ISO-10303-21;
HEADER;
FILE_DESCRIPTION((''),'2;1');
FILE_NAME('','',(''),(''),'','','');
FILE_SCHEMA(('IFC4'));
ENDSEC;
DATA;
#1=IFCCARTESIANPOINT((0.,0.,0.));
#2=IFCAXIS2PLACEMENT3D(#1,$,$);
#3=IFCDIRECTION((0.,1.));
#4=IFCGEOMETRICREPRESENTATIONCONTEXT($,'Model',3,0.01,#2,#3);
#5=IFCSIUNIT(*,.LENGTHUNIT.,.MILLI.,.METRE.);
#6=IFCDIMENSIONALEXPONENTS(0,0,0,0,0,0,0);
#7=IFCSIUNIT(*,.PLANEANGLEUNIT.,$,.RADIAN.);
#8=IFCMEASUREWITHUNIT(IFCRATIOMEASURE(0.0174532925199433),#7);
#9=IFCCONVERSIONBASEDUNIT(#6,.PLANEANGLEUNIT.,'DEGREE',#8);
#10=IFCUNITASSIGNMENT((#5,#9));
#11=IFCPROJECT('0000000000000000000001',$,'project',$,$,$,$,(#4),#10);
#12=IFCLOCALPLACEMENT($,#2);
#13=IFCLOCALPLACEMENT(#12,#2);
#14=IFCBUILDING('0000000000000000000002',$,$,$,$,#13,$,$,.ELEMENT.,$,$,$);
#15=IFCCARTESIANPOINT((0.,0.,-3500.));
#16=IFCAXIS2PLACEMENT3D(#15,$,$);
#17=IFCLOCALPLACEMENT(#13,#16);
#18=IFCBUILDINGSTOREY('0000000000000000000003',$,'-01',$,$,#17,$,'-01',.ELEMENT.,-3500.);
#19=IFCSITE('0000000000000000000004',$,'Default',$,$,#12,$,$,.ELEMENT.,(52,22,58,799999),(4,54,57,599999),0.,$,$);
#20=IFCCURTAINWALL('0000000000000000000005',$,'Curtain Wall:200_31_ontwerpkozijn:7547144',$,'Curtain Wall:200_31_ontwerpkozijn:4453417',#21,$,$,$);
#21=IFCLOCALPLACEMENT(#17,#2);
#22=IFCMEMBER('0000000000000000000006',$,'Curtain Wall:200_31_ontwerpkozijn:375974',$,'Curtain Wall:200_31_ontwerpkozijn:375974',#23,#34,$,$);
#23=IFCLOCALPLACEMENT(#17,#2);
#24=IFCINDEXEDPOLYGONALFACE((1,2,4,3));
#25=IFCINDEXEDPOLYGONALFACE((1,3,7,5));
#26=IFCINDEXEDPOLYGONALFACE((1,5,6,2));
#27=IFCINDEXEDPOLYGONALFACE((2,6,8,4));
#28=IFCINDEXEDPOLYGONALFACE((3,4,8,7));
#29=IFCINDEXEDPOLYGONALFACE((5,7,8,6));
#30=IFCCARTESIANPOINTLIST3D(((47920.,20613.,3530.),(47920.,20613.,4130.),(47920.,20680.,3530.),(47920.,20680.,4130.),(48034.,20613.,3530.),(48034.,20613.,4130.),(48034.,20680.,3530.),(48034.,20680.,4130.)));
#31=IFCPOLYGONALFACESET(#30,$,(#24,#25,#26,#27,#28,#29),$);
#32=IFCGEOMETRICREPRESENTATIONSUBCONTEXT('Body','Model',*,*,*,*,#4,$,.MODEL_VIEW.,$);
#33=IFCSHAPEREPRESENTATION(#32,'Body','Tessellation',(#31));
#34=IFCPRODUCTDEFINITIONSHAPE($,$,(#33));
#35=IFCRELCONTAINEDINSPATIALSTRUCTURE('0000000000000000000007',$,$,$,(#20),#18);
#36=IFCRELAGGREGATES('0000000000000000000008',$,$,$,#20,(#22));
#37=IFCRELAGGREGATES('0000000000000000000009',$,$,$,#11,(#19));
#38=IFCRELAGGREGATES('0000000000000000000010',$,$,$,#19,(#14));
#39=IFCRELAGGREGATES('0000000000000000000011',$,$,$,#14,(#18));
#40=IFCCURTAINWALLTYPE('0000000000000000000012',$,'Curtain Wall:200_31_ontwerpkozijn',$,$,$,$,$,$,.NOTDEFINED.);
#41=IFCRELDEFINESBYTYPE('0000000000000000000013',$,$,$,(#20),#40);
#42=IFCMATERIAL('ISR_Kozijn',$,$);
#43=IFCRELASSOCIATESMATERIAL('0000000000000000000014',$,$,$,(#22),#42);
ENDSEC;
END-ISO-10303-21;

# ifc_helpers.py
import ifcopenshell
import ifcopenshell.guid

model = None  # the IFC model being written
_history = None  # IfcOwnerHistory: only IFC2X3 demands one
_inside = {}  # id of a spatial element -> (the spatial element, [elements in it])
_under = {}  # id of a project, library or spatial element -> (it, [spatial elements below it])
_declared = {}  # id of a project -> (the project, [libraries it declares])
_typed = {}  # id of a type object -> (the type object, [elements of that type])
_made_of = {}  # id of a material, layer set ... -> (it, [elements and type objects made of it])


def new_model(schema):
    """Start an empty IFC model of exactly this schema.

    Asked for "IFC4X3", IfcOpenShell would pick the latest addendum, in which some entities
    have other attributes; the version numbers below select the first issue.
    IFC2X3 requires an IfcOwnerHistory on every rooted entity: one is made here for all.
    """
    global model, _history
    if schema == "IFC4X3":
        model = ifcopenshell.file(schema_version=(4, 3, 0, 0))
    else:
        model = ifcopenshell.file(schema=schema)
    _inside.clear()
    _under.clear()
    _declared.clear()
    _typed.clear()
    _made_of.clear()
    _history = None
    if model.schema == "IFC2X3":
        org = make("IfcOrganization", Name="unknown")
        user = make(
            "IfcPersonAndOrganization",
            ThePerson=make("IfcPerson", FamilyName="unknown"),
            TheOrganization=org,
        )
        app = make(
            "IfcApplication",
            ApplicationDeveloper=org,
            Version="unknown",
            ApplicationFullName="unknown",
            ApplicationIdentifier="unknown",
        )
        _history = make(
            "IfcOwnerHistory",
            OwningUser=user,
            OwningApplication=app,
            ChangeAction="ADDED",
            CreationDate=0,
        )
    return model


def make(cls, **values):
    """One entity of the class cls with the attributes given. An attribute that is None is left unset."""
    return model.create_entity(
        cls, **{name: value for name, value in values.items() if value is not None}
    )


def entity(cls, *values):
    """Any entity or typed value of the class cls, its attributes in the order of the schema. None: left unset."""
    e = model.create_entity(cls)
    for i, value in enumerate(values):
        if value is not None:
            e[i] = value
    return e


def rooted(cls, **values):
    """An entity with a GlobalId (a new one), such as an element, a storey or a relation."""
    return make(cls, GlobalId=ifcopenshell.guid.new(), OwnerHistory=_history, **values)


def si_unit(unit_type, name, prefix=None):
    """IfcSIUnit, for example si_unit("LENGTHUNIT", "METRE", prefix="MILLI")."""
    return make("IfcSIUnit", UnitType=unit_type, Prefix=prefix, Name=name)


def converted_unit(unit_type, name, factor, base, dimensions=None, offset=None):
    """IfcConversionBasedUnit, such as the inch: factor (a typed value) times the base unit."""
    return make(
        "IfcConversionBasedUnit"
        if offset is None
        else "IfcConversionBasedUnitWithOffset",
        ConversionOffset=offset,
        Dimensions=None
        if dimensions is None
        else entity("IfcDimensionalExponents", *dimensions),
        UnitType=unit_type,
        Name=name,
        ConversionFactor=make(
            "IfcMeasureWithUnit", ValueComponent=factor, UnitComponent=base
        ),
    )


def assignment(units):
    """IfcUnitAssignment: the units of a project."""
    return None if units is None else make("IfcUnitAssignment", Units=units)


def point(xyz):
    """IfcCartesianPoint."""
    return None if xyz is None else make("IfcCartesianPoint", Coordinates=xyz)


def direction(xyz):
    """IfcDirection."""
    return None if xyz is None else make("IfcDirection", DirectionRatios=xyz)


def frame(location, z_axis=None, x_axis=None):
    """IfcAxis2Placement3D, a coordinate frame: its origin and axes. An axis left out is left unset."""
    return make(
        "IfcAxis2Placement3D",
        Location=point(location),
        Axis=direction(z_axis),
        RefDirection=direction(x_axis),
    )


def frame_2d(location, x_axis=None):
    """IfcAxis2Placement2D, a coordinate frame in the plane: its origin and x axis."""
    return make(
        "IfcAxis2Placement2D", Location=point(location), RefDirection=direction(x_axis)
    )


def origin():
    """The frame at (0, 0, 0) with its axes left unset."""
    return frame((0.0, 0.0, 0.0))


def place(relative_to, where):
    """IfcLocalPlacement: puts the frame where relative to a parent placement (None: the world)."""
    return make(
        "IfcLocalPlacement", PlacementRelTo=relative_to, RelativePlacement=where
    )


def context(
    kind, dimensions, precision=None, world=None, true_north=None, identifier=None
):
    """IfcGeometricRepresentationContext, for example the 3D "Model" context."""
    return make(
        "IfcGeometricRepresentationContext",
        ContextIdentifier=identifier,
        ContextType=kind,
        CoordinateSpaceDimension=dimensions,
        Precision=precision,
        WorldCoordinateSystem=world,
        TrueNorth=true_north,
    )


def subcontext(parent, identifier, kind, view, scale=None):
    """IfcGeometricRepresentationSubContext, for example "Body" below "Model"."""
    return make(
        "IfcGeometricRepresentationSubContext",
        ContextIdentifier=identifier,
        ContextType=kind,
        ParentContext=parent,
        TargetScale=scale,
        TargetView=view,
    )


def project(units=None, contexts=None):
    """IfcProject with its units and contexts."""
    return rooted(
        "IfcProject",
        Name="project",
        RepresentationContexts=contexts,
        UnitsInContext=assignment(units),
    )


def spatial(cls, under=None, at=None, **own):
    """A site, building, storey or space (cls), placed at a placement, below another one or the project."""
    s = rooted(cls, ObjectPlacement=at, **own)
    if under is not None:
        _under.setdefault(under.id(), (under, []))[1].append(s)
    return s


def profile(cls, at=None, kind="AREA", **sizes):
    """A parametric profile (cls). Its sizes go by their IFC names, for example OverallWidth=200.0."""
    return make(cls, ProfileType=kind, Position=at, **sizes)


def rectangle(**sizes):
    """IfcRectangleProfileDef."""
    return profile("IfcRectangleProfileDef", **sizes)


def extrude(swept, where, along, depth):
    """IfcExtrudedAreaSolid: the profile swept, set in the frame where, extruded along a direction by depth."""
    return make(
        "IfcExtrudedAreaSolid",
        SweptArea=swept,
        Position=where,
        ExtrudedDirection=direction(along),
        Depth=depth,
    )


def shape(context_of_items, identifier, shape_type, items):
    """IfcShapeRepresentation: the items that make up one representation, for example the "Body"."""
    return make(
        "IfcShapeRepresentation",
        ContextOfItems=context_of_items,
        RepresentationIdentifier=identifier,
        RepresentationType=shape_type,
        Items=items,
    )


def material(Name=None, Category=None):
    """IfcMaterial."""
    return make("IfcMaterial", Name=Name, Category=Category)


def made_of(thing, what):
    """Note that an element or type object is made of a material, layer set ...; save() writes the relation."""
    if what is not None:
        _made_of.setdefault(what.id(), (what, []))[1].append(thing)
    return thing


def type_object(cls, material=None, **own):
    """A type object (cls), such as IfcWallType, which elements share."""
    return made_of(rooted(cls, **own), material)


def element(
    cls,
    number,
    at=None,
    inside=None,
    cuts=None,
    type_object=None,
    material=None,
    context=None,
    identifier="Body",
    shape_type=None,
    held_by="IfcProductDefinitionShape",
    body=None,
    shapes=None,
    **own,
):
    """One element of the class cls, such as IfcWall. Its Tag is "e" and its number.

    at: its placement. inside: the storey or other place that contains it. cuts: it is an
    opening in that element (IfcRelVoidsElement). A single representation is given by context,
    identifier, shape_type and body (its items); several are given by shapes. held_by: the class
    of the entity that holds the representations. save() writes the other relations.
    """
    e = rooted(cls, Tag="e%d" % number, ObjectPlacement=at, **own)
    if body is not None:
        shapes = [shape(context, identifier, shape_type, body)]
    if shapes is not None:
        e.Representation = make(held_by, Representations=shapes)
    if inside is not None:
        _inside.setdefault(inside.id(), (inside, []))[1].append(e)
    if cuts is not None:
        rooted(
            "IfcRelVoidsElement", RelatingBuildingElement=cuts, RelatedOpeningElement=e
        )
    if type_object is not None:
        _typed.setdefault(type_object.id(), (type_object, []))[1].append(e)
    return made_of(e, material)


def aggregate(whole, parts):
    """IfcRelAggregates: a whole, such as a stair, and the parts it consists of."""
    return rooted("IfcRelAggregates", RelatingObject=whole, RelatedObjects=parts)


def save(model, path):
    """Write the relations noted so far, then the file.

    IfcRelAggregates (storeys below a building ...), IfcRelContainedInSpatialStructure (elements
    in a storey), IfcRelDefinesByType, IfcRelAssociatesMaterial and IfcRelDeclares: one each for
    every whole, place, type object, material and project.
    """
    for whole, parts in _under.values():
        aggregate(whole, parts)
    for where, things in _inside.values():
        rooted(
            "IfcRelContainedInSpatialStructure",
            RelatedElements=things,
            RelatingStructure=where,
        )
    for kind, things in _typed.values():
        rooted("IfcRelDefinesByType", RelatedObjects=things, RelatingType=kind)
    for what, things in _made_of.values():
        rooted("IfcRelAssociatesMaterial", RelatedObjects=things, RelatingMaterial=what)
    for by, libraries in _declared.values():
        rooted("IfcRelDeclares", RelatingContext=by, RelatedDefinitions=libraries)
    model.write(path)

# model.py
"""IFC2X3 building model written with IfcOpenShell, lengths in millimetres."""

from ifc_helpers import new_model, entity, si_unit, converted_unit, direction, frame, frame_2d, origin, place, context, subcontext, project, spatial, rectangle, extrude, material, type_object, element, aggregate, save


model = new_model("IFC2X3")

# Units and contexts
model_context = context("Model", 3, precision=0.01, world=origin(), true_north=direction((0.0, 1.0)))
body_context = subcontext(model_context, "Body", "Model", "MODEL_VIEW")
ifc_project = project(units=[si_unit("LENGTHUNIT", "METRE", prefix="MILLI"), converted_unit("PLANEANGLEUNIT", "DEGREE", entity("IfcRatioMeasure", 0.0174532925199433), si_unit("PLANEANGLEUNIT", "RADIAN"), dimensions=[0, 0, 0, 0, 0, 0, 0])], contexts=[model_context])

# Site, building, storey
site_placement = place(None, origin())
site = spatial("IfcSite", under=ifc_project, at=site_placement, Name="Default", CompositionType="ELEMENT", RefLatitude=(52, 22, 58, 799999), RefLongitude=(4, 54, 57, 599999), RefElevation=0.0)
building_placement = place(site_placement, origin())
building = spatial("IfcBuilding", under=site, at=building_placement, CompositionType="ELEMENT")
storey_placement = place(building_placement, frame((0.0, 0.0, -3500.0)))
storey = spatial("IfcBuildingStorey", under=building, at=storey_placement, Name="-01", LongName="-01", CompositionType="ELEMENT", Elevation=-3500.0)

# Shared definitions
curtain_wall_type = type_object("IfcCurtainWallType", Name="Curtain Wall:200_31_ontwerpkozijn", PredefinedType="NOTDEFINED")
ifc_material = material(Name="ISR_Kozijn")

# Curtain wall, member
curtain_wall_1_placement = place(storey_placement, frame((0.0, 0.0, 3500.0)))
curtain_wall_1 = element("IfcCurtainWall", 1, at=curtain_wall_1_placement, inside=storey, type_object=curtain_wall_type, Name="Curtain Wall:200_31_ontwerpkozijn:7547144", ObjectType="Curtain Wall:200_31_ontwerpkozijn:4453417")
member_1_placement = place(curtain_wall_1_placement, frame((0.0, 0.0, -3500.0)))
member_1 = element("IfcMember", 2, at=member_1_placement, material=ifc_material, Name="Curtain Wall:200_31_ontwerpkozijn:375974", ObjectType="Curtain Wall:200_31_ontwerpkozijn:375974", context=body_context, shape_type="SweptSolid", body=[
    extrude(rectangle(XDim=114.0, YDim=67.0, at=frame_2d((0.0, 0.0), x_axis=(1.0, 0.0))), frame((47977.0, 20646.5, 4130.0), z_axis=(0.0, 0.0, -1.0), x_axis=(-1.0, 0.0, 0.0)), (0.0, 0.0, 1.0), 600.0),
])
aggregate(curtain_wall_1, [member_1])

save(model, "model.ifc")
